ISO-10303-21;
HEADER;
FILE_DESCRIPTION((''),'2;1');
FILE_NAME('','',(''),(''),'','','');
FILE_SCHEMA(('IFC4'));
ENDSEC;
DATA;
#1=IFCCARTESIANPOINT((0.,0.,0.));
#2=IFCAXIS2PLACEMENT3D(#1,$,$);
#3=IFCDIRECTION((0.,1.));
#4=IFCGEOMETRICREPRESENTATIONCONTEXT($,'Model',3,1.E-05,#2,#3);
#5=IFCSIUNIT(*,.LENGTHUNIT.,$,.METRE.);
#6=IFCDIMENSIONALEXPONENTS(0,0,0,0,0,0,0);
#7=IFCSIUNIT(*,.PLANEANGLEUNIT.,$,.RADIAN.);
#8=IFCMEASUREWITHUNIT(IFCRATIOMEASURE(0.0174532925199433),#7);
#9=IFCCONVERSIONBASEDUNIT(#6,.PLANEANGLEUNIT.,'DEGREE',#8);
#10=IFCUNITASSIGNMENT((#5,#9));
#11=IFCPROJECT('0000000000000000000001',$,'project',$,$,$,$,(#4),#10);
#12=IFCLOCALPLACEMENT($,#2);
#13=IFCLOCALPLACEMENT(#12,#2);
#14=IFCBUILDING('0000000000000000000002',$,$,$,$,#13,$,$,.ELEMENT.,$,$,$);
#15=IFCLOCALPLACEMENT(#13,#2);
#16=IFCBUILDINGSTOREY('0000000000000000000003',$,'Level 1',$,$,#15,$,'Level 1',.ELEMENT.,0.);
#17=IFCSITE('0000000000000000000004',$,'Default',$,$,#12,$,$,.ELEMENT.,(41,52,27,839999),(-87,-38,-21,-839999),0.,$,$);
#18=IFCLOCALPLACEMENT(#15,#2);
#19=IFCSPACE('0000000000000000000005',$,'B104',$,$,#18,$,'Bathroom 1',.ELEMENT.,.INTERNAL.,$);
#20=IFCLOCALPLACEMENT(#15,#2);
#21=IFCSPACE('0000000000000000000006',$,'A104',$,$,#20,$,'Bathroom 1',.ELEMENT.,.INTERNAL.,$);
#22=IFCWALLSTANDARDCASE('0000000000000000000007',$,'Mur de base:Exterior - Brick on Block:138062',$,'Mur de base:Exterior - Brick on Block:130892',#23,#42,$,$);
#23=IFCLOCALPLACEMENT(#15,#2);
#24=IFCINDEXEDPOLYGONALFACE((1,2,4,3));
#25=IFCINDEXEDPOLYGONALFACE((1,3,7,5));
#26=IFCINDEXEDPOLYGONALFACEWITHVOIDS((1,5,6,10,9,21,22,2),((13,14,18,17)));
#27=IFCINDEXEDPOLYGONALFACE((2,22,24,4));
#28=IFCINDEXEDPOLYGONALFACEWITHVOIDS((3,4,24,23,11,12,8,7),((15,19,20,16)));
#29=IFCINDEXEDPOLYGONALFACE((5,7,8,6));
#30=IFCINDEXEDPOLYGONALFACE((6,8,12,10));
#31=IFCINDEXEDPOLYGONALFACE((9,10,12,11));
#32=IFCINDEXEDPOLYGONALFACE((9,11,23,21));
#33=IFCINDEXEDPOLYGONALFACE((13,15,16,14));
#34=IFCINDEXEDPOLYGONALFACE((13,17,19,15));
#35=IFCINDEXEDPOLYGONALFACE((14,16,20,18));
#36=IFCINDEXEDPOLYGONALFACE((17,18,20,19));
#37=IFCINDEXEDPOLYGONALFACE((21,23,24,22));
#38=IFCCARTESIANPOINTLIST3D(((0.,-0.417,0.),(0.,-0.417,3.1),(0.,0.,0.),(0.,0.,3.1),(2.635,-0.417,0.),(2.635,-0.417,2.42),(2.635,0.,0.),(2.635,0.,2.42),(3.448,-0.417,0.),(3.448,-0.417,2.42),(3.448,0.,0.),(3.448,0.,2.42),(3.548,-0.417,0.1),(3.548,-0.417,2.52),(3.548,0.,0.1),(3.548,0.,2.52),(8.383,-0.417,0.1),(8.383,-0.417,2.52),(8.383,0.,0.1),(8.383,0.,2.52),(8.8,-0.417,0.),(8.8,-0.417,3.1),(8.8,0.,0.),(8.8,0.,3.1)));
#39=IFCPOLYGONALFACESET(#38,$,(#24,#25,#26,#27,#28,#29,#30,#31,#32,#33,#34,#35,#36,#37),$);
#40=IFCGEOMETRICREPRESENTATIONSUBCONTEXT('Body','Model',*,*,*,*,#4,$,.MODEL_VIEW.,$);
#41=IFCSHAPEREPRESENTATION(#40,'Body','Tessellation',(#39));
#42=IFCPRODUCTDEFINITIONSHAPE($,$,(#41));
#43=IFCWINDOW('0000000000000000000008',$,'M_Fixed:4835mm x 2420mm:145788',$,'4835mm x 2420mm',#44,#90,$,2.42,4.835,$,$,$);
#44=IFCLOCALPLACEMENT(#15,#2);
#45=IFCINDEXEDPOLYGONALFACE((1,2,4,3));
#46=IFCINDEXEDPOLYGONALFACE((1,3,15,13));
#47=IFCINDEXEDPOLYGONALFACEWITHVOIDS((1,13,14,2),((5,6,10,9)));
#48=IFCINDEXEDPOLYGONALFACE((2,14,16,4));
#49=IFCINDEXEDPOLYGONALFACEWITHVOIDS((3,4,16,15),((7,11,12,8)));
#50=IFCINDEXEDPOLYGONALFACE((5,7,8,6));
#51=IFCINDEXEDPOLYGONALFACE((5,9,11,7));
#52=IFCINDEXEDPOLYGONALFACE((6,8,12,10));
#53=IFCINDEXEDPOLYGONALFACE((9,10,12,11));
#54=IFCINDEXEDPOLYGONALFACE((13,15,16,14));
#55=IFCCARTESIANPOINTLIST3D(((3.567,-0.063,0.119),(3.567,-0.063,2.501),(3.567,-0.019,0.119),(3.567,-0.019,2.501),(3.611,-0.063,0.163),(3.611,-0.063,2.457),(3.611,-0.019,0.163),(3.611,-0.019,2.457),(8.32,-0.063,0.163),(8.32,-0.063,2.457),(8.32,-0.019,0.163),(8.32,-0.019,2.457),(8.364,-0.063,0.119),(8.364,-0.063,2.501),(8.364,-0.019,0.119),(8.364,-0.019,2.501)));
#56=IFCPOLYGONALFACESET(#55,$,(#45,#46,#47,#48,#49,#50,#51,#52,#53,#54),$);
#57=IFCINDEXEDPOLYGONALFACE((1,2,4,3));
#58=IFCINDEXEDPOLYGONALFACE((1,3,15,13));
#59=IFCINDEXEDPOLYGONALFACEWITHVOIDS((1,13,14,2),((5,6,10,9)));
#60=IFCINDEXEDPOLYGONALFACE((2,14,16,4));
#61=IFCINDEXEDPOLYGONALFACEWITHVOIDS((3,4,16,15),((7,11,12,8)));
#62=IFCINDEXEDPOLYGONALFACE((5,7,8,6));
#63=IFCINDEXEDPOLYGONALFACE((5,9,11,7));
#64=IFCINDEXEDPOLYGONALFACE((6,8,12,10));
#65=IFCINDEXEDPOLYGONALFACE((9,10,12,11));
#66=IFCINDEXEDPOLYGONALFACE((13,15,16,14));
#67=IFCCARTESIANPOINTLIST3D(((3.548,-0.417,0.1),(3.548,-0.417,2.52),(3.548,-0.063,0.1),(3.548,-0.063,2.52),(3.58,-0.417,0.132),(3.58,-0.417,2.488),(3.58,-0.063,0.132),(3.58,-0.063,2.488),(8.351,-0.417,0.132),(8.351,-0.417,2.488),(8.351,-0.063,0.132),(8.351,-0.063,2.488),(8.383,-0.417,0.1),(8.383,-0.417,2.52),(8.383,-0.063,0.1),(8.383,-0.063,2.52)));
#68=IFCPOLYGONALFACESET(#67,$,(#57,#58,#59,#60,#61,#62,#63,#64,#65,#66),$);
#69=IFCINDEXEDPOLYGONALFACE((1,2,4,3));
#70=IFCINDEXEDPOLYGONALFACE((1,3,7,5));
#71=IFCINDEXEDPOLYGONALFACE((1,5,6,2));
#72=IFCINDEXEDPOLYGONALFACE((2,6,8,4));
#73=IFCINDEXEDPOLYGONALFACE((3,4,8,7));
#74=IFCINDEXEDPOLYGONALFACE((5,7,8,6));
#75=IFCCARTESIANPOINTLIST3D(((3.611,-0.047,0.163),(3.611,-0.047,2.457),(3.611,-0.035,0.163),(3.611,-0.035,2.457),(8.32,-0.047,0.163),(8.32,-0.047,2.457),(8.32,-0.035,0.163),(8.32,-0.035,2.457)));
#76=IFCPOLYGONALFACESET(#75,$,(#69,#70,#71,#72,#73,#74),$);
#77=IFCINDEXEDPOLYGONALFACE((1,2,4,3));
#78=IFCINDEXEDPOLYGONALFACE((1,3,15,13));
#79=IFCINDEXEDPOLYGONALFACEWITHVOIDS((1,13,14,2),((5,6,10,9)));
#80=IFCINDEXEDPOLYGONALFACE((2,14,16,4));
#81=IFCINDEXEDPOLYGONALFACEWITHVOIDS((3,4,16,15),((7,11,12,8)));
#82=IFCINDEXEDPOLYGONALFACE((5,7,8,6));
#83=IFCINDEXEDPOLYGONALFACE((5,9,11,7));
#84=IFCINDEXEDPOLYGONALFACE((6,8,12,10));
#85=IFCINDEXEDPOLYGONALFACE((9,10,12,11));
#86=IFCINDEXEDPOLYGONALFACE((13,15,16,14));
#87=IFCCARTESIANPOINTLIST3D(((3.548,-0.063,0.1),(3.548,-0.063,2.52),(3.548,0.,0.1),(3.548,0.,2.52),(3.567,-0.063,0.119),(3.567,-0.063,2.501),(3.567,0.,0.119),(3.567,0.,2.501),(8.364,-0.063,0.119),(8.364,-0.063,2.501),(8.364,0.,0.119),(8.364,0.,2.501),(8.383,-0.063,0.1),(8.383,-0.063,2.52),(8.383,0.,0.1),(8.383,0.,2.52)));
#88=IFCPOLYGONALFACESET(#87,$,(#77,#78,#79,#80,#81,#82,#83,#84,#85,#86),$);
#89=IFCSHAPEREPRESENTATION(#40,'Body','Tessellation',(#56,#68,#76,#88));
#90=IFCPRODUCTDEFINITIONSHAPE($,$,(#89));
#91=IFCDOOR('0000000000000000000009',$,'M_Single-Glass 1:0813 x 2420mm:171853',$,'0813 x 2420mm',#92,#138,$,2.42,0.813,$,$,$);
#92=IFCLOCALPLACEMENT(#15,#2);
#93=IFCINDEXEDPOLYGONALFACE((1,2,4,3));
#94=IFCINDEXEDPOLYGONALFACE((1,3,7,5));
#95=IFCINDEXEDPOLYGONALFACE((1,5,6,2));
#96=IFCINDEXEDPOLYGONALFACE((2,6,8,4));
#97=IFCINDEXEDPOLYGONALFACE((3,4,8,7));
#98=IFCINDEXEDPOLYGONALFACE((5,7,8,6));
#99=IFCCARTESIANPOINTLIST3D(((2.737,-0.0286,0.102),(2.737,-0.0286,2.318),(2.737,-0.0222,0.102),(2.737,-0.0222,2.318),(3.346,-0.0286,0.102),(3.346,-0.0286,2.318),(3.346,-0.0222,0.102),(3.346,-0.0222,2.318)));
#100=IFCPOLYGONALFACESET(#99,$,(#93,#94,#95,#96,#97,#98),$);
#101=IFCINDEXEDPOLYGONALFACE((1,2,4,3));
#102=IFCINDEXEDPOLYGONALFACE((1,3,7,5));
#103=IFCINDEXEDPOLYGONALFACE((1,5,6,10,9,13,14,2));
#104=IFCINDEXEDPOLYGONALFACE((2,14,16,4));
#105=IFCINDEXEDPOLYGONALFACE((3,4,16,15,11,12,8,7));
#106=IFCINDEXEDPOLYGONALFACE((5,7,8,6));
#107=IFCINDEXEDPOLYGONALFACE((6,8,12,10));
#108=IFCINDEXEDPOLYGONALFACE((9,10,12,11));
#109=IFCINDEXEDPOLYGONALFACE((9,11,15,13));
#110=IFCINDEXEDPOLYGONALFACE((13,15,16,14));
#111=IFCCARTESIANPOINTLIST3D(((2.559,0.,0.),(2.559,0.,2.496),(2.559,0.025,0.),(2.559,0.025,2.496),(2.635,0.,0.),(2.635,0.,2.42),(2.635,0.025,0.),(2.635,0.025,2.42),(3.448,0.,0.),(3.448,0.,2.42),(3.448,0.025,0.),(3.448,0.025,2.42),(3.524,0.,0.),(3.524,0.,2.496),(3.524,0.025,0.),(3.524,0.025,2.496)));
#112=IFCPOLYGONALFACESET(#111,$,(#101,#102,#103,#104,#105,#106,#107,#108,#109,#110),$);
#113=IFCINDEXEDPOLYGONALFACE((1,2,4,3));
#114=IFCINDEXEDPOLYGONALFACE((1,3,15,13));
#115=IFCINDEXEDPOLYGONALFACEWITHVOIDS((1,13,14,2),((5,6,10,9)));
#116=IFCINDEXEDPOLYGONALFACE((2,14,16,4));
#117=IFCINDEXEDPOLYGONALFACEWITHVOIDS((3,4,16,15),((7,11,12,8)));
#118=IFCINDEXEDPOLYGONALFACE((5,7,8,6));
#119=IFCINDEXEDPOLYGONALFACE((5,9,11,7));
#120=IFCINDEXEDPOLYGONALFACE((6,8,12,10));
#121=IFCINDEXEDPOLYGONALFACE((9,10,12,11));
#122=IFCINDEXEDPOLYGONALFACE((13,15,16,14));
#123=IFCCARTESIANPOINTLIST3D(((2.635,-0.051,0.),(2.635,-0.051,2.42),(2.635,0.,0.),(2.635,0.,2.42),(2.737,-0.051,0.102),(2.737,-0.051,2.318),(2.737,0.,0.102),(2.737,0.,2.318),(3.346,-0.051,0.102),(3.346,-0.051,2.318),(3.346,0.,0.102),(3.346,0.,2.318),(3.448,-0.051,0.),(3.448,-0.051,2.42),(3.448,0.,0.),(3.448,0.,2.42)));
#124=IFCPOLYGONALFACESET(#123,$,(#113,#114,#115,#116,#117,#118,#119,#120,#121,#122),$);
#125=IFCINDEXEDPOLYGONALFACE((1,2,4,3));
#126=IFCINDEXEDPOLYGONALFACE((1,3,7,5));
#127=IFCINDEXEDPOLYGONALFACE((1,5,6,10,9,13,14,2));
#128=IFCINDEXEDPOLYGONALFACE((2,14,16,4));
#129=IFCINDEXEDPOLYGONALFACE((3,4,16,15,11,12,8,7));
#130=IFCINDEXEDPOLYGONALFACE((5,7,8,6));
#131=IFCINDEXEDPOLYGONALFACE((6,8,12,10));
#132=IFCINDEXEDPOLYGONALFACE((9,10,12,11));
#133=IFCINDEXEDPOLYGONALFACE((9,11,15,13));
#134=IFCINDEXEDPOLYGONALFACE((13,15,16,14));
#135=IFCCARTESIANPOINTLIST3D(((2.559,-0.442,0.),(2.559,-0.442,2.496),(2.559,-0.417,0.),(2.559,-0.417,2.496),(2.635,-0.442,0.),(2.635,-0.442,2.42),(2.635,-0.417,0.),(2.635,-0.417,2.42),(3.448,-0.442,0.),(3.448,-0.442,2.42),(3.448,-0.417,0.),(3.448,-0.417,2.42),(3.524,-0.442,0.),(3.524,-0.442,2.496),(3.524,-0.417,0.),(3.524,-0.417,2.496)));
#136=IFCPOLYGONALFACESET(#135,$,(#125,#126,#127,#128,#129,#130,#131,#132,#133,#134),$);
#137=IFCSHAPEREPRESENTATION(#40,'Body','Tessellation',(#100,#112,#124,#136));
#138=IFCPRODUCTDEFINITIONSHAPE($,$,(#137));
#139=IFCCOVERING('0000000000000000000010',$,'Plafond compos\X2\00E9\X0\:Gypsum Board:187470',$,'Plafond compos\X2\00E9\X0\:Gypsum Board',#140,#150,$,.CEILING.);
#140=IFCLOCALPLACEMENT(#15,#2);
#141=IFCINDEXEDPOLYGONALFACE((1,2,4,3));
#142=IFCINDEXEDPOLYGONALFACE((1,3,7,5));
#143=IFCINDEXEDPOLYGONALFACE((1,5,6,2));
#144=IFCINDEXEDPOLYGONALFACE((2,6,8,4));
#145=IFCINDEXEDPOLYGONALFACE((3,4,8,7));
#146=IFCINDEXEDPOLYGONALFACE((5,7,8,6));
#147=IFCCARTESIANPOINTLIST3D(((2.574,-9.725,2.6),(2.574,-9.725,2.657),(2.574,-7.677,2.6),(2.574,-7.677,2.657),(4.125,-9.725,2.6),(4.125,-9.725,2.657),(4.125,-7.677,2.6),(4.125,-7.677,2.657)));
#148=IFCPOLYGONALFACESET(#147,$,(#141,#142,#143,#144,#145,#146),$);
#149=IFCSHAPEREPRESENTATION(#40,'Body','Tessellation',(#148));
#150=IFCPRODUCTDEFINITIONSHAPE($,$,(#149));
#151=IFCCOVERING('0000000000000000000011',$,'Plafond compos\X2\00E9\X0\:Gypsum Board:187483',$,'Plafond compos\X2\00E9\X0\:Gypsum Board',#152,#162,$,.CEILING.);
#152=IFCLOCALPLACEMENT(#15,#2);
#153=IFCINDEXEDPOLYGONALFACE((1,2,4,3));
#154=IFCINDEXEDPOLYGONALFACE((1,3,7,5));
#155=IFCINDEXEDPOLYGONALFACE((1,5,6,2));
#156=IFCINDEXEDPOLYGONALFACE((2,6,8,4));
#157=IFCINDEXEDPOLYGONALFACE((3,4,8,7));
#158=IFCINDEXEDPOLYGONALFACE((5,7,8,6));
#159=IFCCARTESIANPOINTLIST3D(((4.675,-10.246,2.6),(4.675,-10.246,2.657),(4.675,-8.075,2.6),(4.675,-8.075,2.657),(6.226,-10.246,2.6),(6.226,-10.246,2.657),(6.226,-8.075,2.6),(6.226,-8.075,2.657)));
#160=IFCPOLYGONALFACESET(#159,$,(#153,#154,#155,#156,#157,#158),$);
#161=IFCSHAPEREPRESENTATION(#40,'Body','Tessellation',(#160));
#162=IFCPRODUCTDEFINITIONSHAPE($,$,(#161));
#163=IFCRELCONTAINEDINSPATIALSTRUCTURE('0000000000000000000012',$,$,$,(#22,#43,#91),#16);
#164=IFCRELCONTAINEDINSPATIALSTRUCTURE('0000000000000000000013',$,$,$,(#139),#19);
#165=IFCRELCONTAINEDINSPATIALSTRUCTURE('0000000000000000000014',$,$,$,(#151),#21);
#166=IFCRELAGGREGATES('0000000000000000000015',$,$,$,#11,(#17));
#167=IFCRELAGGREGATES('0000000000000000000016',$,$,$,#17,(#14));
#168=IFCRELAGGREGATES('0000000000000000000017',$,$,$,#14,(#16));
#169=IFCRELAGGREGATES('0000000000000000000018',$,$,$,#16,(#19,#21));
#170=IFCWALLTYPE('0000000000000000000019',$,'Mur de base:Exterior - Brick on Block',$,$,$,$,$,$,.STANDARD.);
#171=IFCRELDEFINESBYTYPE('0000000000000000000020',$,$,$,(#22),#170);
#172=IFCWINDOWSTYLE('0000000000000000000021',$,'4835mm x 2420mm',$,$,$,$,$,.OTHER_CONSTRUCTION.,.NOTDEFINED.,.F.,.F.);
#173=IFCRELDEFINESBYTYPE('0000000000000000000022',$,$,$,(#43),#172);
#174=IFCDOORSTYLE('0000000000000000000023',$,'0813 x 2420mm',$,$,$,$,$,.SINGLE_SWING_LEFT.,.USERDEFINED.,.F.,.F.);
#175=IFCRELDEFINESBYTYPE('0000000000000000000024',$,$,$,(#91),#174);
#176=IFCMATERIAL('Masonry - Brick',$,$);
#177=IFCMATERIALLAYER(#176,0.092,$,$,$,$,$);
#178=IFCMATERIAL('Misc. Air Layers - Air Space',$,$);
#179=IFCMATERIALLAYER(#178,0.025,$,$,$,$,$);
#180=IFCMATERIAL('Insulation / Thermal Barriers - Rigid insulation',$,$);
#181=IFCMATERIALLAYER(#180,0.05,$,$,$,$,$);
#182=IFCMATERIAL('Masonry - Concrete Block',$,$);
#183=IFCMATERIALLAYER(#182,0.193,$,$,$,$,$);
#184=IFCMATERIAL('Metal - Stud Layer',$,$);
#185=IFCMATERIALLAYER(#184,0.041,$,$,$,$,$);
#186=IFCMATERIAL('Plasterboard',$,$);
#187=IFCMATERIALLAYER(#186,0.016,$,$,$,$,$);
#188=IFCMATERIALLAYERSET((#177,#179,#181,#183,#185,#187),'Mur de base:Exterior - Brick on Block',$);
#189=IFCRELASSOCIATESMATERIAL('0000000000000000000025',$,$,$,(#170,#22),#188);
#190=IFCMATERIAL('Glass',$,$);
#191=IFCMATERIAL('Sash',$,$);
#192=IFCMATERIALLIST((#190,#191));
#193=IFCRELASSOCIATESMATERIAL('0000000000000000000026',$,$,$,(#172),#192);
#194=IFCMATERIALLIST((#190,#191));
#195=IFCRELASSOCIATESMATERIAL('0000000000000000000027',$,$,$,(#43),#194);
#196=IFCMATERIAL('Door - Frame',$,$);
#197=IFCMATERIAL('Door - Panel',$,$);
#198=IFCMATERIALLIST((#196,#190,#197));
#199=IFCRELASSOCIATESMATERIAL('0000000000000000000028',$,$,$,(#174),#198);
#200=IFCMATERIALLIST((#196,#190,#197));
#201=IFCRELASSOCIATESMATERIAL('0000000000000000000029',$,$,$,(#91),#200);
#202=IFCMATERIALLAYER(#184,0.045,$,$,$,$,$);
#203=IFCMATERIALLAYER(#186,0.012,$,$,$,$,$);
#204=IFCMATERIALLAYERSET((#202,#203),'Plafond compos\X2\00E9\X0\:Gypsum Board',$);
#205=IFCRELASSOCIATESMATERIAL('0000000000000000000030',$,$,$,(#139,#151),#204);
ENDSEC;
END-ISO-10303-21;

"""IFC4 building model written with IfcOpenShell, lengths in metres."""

from ifc_helpers import new_model, entity, si_unit, converted_unit, direction, frame, frame_2d, origin, origin_2d_with_axis, place, context, subcontext, project, spatial, polyline, rectangle, outline, extrude, source, transform, mapped, material, material_list, layer, layer_set, layer_usage, type_object, type_shapes, element, fill, save


model = new_model("IFC4")

# Units and contexts
model_context = context("Model", 3, precision=1e-05, world=origin(), true_north=direction((0.0, 1.0)))
body_context = subcontext(model_context, "Body", "Model", "MODEL_VIEW")
ifc_project = project(units=[si_unit("LENGTHUNIT", "METRE"), converted_unit("PLANEANGLEUNIT", "DEGREE", entity("IfcRatioMeasure", 0.0174532925199433), si_unit("PLANEANGLEUNIT", "RADIAN"), dimensions=[0, 0, 0, 0, 0, 0, 0])], contexts=[model_context])

# Site, building, storey
site_placement = place(None, origin())
site = spatial("IfcSite", under=ifc_project, at=site_placement, Name="Default", CompositionType="ELEMENT", RefLatitude=(41, 52, 27, 839999), RefLongitude=(-87, -38, -21, -839999), RefElevation=0.0)
building_placement = place(site_placement, origin())
building = spatial("IfcBuilding", under=site, at=building_placement, CompositionType="ELEMENT")
storey_placement = place(building_placement, origin())
storey = spatial("IfcBuildingStorey", under=building, at=storey_placement, Name="Level 1", LongName="Level 1", CompositionType="ELEMENT", Elevation=0.0)

# Shared definitions
ifc_material_1 = material(Name="Plasterboard")
ifc_material_2 = material(Name="Metal - Stud Layer")

# Wall, openings, window, door
ifc_material_3 = material(Name="Masonry - Brick")
ifc_layer_1 = layer(ifc_material_3, 0.092)
ifc_material_4 = material(Name="Misc. Air Layers - Air Space")
ifc_layer_2 = layer(ifc_material_4, 0.025)
ifc_material_5 = material(Name="Insulation / Thermal Barriers - Rigid insulation")
ifc_layer_3 = layer(ifc_material_5, 0.05)
ifc_material_6 = material(Name="Masonry - Concrete Block")
ifc_layer_4 = layer(ifc_material_6, 0.193)
ifc_layer_5 = layer(ifc_material_2, 0.041)
ifc_layer_6 = layer(ifc_material_1, 0.016)
ifc_layer_set_1 = layer_set([ifc_layer_1, ifc_layer_2, ifc_layer_3, ifc_layer_4, ifc_layer_5, ifc_layer_6], Name="Mur de base:Exterior - Brick on Block")
ifc_layer_usage_1 = layer_usage(ifc_layer_set_1, "AXIS2", "NEGATIVE", 0.2085)
wall_type_1 = type_object("IfcWallType", Name="Mur de base:Exterior - Brick on Block", PredefinedType="STANDARD", material=ifc_layer_set_1)
wall_1_placement = place(storey_placement, frame((0.0, -0.2085, 0.0)))
wall_1 = element("IfcWallStandardCase", 1, at=wall_1_placement, inside=storey, type_object=wall_type_1, material=ifc_layer_usage_1, Name="Mur de base:Exterior - Brick on Block:138062", ObjectType="Mur de base:Exterior - Brick on Block:130892", context=body_context, shape_type="SweptSolid", body=[
    extrude(rectangle(XDim=8.8, YDim=0.417, at=frame_2d((4.4, 0.0), x_axis=(-1.0, 0.0))), origin(), (0.0, 0.0, 1.0), 3.1),
])
opening_1_placement = place(wall_1_placement, frame((3.548, -0.2085, 0.1)))
opening_1 = element("IfcOpeningElement", 2, at=opening_1_placement, cuts=wall_1, ObjectType="Opening", context=body_context, shape_type="SweptSolid", body=[
    extrude(rectangle(XDim=2.42, YDim=4.835, at=frame_2d((1.21, 2.4175), x_axis=(1.0, 0.0))), frame((0.0, 0.0, 0.0), z_axis=(0.0, 1.0, 0.0), x_axis=(0.0, 0.0, 1.0)), (0.0, 0.0, 1.0), 0.417),
])
opening_2_placement = place(wall_1_placement, frame((2.635, -0.2085, 0.0)))
opening_2 = element("IfcOpeningElement", 3, at=opening_2_placement, cuts=wall_1, ObjectType="Opening", context=body_context, shape_type="SweptSolid", body=[
    extrude(rectangle(XDim=0.813, YDim=2.42, at=frame_2d((1.21, 0.4065), x_axis=(0.0, -1.0))), frame((0.0, 0.0, 0.0), z_axis=(0.0, 1.0, 0.0), x_axis=(0.0, 0.0, 1.0)), (0.0, 0.0, 1.0), 0.417),
])
ifc_material_7 = material(Name="Glass")
ifc_material_8 = material(Name="Sash")
ifc_material_list_1 = material_list([ifc_material_7, ifc_material_8])
ifc_material_list_2 = material_list([ifc_material_7, ifc_material_8])
window_style = type_object("IfcWindowStyle", Name="4835mm x 2420mm", ConstructionType="OTHER_CONSTRUCTION", OperationType="NOTDEFINED", ParameterTakesPrecedence=False, Sizeable=False, material=ifc_material_list_2)
shared_shape_1 = source(origin(), body_context, "Body", "SweptSolid", [
    extrude(outline(polyline([(-2.3985, -1.191), (2.3985, -1.191), (2.3985, 1.191), (-2.3985, 1.191), (-2.3985, -1.191)]), holes=[polyline([(-2.3545, -1.147), (-2.3545, 1.147), (2.3545, 1.147), (2.3545, -1.147), (-2.3545, -1.147)])]), frame((2.4175, 0.354, 1.21), z_axis=(0.0, 1.0, 0.0), x_axis=(1.0, 0.0, 0.0)), (0.0, 0.0, 1.0), 0.044),
    extrude(outline(polyline([(-2.4175, -1.21), (2.4175, -1.21), (2.4175, 1.21), (-2.4175, 1.21), (-2.4175, -1.21)]), holes=[polyline([(-2.3855, -1.178), (-2.3855, 1.178), (2.3855, 1.178), (2.3855, -1.178), (-2.3855, -1.178)])]), frame((2.4175, 0.0, 1.21), z_axis=(0.0, 1.0, 0.0), x_axis=(1.0, 0.0, 0.0)), (0.0, 0.0, 1.0), 0.354),
    extrude(rectangle(XDim=0.012, YDim=4.709, at=origin_2d_with_axis()), frame((2.4175, 0.376, 0.063), z_axis=(0.0, 0.0, 1.0), x_axis=(0.0, -1.0, 0.0)), (0.0, 0.0, 1.0), 2.294),
    extrude(outline(polyline([(-2.4175, -1.21), (2.4175, -1.21), (2.4175, 1.21), (-2.4175, 1.21), (-2.4175, -1.21)]), holes=[polyline([(-2.3985, -1.191), (-2.3985, 1.191), (2.3985, 1.191), (2.3985, -1.191), (-2.3985, -1.191)])]), frame((2.4175, 0.354, 1.21), z_axis=(0.0, 1.0, 0.0), x_axis=(1.0, 0.0, 0.0)), (0.0, 0.0, 1.0), 0.063),
])
type_shapes(window_style, [shared_shape_1])
window_placement = place(opening_1_placement, origin())
window = element("IfcWindow", 4, at=window_placement, inside=storey, type_object=window_style, material=ifc_material_list_1, Name="M_Fixed:4835mm x 2420mm:145788", ObjectType="4835mm x 2420mm", OverallHeight=2.42, OverallWidth=4.835, context=body_context, shape_type="MappedRepresentation", body=[
    mapped(shared_shape_1, transform((0.0, 0.0, 0.0), scale=1.0)),
])
fill(opening_1, window)
ifc_material_9 = material(Name="Door - Frame")
ifc_material_10 = material(Name="Door - Panel")
ifc_material_list_3 = material_list([ifc_material_9, ifc_material_7, ifc_material_10])
ifc_material_list_4 = material_list([ifc_material_9, ifc_material_7, ifc_material_10])
door_style = type_object("IfcDoorStyle", Name="0813 x 2420mm", ConstructionType="USERDEFINED", OperationType="SINGLE_SWING_LEFT", ParameterTakesPrecedence=False, Sizeable=False, material=ifc_material_list_4)
shared_shape_2 = source(origin(), body_context, "Body", "SweptSolid", [
    extrude(rectangle(XDim=0.609, YDim=0.0064, at=frame_2d((0.0, 0.0), x_axis=(1.0, 0.0))), frame((0.4065, 0.3916, 0.102)), (0.0, 0.0, 1.0), 2.216),
    extrude(outline(polyline([(-0.4065, -1.191), (-0.4065, 1.229), (-0.4825, 1.229), (-0.4825, -1.267), (0.4825, -1.267), (0.4825, 1.229), (0.4065, 1.229), (0.4065, -1.191), (-0.4065, -1.191)])), frame((0.4065, 0.442, 1.229), z_axis=(0.0, 1.0, 0.0), x_axis=(1.0, 0.0, 0.0)), (0.0, 0.0, -1.0), 0.025),
    extrude(outline(polyline([(-1.21, -0.4065), (1.21, -0.4065), (1.21, 0.4065), (-1.21, 0.4065), (-1.21, -0.4065)]), holes=[polyline([(-1.108, 0.3045), (1.108, 0.3045), (1.108, -0.3045), (-1.108, -0.3045), (-1.108, 0.3045)])]), frame((0.4065, 0.417, 1.21), z_axis=(0.0, -1.0, 0.0), x_axis=(0.0, 0.0, -1.0)), (0.0, 0.0, 1.0), 0.051),
    extrude(outline(polyline([(-0.4065, -1.191), (-0.4065, 1.229), (-0.4825, 1.229), (-0.4825, -1.267), (0.4825, -1.267), (0.4825, 1.229), (0.4065, 1.229), (0.4065, -1.191), (-0.4065, -1.191)])), frame((0.4065, 0.0, 1.229), z_axis=(0.0, 1.0, 0.0), x_axis=(1.0, 0.0, 0.0)), (0.0, 0.0, -1.0), 0.025),
])
type_shapes(door_style, [shared_shape_2])
door_placement = place(opening_2_placement, origin())
door = element("IfcDoor", 5, at=door_placement, inside=storey, type_object=door_style, material=ifc_material_list_3, Name="M_Single-Glass 1:0813 x 2420mm:171853", ObjectType="0813 x 2420mm", OverallHeight=2.42, OverallWidth=0.813, context=body_context, shape_type="MappedRepresentation", body=[
    mapped(shared_shape_2, transform((0.0, 0.0, 0.0), scale=1.0)),
])
fill(opening_2, door)

# Shared definitions
space_1_placement = place(storey_placement, origin())
space_1 = spatial("IfcSpace", under=storey, at=space_1_placement, Name="B104", LongName="Bathroom 1", CompositionType="ELEMENT", PredefinedType="INTERNAL")

# Covering
ifc_layer_7 = layer(ifc_material_2, 0.045)
ifc_layer_8 = layer(ifc_material_1, 0.012)
ifc_layer_set_2 = layer_set([ifc_layer_7, ifc_layer_8], Name="Plafond composé:Gypsum Board")
ifc_layer_usage_2 = layer_usage(ifc_layer_set_2, "AXIS3", "NEGATIVE", 0.0)
covering_1_placement = place(space_1_placement, origin())
element("IfcCovering", 6, at=covering_1_placement, inside=space_1, material=ifc_layer_usage_2, Name="Plafond composé:Gypsum Board:187470", ObjectType="Plafond composé:Gypsum Board", PredefinedType="CEILING", context=body_context, shape_type="SweptSolid", body=[
    extrude(rectangle(XDim=1.551, YDim=2.048, at=frame_2d((0.0, 0.0), x_axis=(1.0, 0.0))), frame((3.3495, -8.701, 2.6)), (0.0, 0.0, 1.0), 0.057),
])

# Shared definitions
space_2_placement = place(storey_placement, origin())
space_2 = spatial("IfcSpace", under=storey, at=space_2_placement, Name="A104", LongName="Bathroom 1", CompositionType="ELEMENT", PredefinedType="INTERNAL")

# Covering
ifc_layer_usage_3 = layer_usage(ifc_layer_set_2, "AXIS3", "NEGATIVE", 0.0)
covering_2_placement = place(space_2_placement, origin())
element("IfcCovering", 7, at=covering_2_placement, inside=space_2, material=ifc_layer_usage_3, Name="Plafond composé:Gypsum Board:187483", ObjectType="Plafond composé:Gypsum Board", PredefinedType="CEILING", context=body_context, shape_type="SweptSolid", body=[
    extrude(rectangle(XDim=2.171, YDim=1.551, at=frame_2d((0.0, 0.0), x_axis=(1.0, 0.0))), frame((5.4505, -9.1605, 2.6), z_axis=(0.0, 0.0, 1.0), x_axis=(0.0, -1.0, 0.0)), (0.0, 0.0, 1.0), 0.057),
])

save(model, "model.ifc")
